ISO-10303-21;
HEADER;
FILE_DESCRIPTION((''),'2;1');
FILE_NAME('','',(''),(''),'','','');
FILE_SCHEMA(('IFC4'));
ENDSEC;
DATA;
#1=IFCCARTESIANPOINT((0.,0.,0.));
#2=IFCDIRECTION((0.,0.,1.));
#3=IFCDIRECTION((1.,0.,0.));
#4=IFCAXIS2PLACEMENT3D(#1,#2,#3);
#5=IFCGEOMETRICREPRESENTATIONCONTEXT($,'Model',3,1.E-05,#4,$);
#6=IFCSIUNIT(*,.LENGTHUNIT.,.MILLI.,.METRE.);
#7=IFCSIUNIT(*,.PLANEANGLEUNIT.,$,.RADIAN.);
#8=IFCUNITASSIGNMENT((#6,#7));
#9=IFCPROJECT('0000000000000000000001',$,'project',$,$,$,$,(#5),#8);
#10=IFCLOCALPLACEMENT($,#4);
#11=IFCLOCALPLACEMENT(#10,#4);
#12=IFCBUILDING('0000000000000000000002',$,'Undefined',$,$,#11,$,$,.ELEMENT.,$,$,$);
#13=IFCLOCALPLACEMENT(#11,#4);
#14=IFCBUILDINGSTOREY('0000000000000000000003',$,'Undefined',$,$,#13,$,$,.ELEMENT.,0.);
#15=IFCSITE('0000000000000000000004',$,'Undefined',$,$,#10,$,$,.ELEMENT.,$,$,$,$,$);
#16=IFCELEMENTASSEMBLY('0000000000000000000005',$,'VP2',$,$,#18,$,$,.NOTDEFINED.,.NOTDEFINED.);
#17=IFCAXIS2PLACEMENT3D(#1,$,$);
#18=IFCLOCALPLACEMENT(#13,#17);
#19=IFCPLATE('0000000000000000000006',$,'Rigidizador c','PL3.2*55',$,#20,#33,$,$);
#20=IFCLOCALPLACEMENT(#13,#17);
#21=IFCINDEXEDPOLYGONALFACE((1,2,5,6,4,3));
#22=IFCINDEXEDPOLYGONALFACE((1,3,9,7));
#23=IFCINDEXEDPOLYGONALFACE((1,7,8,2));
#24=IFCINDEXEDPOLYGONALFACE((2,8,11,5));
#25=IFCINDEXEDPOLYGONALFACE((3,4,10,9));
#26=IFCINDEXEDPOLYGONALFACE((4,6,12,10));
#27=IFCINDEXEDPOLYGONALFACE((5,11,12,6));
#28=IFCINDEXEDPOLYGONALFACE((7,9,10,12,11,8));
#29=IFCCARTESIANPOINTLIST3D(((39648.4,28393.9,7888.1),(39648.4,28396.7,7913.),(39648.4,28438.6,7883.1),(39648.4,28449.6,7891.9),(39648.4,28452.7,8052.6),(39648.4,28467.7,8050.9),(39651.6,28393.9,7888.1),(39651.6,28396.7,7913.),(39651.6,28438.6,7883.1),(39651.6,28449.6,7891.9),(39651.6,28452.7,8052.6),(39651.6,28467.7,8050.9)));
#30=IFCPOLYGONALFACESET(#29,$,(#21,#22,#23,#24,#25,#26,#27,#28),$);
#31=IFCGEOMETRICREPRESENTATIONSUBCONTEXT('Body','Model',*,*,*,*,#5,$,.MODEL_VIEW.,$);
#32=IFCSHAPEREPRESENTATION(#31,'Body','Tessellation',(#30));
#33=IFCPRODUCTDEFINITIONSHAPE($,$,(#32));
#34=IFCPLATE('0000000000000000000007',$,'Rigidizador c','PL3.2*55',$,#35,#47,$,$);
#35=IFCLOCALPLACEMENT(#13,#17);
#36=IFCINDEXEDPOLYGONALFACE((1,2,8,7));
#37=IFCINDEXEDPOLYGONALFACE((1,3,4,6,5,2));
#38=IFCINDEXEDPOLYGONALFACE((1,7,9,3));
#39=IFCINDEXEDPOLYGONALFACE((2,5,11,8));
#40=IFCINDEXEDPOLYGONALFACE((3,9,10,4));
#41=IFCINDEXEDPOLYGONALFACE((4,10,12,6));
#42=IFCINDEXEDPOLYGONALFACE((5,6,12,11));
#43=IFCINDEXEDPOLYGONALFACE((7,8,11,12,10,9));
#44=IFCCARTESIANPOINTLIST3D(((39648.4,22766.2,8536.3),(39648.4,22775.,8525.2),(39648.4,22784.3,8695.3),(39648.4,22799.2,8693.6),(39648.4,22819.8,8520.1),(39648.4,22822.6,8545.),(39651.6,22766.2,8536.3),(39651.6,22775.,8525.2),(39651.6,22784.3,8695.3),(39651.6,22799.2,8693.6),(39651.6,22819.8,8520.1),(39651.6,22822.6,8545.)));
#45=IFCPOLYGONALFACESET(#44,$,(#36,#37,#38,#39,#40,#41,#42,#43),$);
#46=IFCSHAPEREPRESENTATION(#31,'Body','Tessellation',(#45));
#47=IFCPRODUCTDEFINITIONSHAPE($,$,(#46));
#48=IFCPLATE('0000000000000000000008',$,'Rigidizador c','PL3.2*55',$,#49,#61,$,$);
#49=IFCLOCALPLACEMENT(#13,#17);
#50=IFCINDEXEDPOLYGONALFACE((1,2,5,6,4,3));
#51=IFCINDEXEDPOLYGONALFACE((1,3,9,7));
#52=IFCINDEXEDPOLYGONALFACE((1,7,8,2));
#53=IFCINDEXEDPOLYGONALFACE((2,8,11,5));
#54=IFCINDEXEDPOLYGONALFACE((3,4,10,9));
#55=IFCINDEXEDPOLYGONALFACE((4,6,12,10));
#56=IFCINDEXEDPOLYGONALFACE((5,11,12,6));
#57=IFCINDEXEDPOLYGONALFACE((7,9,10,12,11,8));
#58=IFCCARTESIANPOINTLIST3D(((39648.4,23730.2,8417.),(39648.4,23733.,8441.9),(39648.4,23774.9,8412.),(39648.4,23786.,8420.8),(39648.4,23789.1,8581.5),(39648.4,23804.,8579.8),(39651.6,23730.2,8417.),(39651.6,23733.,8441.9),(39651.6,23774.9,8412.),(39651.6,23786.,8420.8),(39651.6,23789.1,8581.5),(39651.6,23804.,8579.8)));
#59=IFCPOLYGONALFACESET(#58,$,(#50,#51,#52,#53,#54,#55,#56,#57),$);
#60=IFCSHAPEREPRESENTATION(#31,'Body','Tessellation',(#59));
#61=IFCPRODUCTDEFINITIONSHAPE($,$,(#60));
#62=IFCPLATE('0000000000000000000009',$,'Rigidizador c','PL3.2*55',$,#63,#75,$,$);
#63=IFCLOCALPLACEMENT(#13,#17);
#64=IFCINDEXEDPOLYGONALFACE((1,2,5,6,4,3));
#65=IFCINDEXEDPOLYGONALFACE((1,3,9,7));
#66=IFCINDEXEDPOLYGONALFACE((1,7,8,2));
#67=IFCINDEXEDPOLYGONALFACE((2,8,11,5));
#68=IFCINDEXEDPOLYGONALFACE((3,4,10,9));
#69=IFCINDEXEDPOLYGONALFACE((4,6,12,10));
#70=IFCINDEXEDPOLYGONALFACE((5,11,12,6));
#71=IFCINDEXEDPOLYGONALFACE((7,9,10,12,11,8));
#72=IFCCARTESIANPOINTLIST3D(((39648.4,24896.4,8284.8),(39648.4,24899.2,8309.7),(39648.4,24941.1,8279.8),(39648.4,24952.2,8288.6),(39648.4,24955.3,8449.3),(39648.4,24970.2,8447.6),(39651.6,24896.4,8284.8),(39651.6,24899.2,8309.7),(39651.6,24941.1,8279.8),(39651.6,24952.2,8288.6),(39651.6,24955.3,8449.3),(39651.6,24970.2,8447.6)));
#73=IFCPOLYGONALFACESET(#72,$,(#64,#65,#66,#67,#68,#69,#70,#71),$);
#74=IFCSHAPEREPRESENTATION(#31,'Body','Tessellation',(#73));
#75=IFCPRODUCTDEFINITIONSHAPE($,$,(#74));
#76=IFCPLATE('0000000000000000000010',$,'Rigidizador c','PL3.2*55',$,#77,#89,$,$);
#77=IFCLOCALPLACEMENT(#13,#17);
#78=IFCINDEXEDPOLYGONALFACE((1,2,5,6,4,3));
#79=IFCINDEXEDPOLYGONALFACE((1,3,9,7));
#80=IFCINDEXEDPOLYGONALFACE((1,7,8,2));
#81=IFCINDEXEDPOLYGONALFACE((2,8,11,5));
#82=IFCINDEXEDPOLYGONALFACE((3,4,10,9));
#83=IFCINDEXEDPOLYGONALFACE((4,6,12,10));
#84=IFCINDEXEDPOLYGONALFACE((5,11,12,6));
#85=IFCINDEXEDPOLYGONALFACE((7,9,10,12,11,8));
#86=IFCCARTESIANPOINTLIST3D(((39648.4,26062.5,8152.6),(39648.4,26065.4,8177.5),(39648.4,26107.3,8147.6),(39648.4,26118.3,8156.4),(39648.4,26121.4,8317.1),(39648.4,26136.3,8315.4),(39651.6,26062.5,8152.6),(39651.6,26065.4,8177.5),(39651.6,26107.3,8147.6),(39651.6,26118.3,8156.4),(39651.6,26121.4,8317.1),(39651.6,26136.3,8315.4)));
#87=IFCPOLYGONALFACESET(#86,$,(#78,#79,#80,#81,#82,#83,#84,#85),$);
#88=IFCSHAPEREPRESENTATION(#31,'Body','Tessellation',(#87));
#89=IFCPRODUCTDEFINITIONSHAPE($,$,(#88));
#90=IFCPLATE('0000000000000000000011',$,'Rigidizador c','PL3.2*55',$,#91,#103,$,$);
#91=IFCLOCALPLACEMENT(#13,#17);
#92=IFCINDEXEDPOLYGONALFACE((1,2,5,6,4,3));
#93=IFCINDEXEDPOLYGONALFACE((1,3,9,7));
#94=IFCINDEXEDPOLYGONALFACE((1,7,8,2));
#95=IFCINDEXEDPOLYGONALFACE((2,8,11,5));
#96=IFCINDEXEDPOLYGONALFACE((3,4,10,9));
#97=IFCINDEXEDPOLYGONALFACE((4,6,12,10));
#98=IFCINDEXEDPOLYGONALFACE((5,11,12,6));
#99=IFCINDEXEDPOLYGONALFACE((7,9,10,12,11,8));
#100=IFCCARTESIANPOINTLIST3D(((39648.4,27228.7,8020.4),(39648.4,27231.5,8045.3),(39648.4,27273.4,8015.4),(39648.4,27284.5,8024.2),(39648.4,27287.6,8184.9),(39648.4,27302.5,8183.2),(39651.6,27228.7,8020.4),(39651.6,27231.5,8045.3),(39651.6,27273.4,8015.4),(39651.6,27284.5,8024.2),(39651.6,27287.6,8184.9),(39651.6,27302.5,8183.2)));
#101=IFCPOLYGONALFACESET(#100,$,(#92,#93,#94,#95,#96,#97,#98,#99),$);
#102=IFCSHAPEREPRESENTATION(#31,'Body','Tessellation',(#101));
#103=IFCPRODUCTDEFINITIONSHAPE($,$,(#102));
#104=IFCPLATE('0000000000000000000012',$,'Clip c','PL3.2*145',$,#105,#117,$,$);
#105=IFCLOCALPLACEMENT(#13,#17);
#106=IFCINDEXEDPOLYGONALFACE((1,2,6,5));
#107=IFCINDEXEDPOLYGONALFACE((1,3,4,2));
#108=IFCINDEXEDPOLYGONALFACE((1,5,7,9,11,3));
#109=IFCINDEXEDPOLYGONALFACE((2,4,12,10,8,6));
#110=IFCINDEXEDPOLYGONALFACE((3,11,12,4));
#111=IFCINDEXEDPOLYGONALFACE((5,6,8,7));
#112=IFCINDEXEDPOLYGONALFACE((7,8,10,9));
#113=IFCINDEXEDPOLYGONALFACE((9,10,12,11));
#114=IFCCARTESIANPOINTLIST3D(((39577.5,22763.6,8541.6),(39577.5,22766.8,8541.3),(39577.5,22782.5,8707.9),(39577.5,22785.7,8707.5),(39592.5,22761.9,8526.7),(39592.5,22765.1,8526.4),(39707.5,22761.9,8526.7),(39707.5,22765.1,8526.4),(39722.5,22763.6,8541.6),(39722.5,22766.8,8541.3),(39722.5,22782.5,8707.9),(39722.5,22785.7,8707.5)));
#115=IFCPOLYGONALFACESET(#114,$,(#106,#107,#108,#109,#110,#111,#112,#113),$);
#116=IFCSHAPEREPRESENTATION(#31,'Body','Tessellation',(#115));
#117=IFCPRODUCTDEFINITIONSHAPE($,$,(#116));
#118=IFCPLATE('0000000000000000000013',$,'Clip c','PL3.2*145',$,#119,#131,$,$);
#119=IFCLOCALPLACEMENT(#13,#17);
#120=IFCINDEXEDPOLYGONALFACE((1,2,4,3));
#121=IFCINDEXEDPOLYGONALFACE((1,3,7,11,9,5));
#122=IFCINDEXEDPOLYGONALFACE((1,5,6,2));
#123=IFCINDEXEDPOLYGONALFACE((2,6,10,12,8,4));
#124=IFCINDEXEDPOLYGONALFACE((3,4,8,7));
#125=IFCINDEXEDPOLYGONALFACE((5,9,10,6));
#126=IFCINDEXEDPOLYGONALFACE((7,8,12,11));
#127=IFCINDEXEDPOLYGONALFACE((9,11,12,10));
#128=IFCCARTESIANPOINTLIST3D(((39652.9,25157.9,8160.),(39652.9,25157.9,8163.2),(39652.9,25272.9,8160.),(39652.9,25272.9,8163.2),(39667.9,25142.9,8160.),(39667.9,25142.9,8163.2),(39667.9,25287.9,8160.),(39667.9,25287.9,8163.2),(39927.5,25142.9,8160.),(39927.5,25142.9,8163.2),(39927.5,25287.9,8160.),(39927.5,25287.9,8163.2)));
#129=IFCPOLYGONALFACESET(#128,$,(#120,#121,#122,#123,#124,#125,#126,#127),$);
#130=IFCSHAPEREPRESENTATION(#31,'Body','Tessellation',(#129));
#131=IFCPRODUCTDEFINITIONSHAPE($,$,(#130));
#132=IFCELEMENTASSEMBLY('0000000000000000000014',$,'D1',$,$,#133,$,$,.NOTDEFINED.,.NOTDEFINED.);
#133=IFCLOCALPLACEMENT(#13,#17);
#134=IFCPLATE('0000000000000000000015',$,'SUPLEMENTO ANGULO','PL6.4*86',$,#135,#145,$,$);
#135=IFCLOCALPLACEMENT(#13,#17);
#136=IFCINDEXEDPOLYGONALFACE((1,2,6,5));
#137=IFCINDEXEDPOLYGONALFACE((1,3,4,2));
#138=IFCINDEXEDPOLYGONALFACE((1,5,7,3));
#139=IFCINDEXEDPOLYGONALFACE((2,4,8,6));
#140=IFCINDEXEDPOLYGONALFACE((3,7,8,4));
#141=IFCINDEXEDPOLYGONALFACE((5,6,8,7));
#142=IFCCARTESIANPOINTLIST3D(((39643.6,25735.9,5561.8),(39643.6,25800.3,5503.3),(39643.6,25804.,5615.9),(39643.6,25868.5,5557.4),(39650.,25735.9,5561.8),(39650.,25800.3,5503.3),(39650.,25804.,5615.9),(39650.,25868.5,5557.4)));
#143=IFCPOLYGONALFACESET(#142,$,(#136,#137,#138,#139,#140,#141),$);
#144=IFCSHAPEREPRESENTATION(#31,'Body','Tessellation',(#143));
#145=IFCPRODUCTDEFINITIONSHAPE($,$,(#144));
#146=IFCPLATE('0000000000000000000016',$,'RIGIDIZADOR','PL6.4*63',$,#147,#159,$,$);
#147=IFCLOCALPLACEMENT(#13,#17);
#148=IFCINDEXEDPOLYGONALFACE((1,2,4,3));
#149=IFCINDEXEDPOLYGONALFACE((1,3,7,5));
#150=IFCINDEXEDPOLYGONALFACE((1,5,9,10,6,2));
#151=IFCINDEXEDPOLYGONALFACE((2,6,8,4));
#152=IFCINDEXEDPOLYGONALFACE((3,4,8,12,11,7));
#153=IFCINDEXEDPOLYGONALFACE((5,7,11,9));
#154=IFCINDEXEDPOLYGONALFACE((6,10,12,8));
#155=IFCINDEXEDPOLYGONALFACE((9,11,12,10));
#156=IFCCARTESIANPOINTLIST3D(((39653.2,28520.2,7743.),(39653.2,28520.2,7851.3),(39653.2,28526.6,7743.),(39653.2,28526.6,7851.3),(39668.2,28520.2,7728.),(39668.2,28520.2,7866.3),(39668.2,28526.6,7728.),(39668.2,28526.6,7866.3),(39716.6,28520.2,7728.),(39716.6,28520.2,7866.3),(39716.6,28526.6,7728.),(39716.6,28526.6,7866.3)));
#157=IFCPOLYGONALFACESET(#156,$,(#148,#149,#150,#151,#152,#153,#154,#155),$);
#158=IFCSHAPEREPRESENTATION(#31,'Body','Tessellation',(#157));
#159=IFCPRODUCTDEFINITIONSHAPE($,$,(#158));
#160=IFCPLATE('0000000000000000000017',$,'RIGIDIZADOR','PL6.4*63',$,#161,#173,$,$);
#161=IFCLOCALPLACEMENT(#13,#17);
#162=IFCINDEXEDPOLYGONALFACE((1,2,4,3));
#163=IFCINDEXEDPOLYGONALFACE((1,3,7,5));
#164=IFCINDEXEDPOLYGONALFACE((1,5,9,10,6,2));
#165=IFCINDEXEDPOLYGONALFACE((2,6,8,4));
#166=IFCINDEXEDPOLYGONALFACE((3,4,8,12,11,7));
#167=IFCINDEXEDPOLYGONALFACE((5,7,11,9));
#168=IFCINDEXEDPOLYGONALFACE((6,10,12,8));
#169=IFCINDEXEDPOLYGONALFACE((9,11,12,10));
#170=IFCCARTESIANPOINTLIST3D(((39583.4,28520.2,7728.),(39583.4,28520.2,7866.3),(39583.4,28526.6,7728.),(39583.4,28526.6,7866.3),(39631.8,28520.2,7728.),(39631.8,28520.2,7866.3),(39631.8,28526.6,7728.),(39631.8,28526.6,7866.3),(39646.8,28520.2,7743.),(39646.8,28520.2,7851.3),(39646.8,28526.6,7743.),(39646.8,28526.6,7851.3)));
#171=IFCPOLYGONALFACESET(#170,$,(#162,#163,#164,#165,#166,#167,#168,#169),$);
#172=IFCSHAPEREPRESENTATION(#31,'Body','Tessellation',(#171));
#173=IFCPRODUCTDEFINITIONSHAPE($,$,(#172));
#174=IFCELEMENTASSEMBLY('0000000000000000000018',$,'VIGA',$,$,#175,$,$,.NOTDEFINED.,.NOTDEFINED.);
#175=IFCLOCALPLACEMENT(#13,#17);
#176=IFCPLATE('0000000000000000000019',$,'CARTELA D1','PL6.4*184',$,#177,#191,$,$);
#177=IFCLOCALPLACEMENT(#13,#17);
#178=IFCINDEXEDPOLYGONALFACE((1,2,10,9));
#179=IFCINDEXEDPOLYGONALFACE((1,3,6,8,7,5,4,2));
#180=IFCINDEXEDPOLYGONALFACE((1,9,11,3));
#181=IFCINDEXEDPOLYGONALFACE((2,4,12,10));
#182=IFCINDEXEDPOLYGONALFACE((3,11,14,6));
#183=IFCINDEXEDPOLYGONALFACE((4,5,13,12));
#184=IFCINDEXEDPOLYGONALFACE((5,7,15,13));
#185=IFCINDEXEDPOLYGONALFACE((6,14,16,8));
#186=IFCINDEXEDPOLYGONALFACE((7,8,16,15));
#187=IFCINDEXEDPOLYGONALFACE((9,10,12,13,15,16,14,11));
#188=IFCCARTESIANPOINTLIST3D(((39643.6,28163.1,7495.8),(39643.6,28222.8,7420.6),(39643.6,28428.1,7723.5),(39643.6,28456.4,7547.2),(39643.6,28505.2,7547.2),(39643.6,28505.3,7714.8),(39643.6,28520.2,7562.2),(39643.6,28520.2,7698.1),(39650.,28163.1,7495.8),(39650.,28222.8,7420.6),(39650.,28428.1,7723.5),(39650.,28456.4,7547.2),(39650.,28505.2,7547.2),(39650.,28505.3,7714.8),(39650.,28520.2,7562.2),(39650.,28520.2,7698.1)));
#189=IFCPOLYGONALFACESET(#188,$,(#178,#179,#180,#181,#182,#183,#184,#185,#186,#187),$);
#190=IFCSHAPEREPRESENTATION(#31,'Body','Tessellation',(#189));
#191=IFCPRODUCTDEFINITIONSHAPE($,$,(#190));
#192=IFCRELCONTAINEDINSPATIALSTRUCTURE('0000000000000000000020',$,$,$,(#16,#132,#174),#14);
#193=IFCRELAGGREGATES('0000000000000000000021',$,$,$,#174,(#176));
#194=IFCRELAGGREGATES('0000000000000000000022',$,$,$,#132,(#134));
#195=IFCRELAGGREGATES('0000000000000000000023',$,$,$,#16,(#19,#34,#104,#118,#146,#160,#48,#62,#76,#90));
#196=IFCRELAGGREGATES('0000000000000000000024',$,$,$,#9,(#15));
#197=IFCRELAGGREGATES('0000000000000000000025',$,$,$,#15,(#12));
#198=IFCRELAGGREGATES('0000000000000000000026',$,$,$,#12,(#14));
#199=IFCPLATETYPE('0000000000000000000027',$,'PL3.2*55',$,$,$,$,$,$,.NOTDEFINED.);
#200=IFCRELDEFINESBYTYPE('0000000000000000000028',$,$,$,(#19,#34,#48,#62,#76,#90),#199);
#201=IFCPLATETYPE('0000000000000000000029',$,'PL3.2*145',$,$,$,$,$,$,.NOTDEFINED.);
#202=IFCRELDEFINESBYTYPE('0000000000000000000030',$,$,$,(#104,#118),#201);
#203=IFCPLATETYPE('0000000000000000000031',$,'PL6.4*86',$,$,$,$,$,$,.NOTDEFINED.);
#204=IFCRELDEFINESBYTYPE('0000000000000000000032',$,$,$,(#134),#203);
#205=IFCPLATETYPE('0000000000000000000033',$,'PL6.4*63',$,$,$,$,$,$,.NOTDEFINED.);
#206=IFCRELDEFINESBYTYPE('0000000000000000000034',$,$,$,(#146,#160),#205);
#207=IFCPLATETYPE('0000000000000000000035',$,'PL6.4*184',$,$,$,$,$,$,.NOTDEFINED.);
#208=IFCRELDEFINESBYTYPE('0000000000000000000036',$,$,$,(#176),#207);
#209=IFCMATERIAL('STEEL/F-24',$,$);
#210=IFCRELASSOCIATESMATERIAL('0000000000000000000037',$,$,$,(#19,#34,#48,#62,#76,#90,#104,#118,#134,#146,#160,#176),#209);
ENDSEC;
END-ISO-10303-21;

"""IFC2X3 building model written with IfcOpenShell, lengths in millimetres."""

from ifc_helpers import new_model, si_unit, frame, origin_with_axes, place, context, subcontext, project, spatial, polyline, outline, extrude, material, type_object, element, aggregate, save


model = new_model("IFC2X3")

# Units and contexts
model_context = context("Model", 3, precision=1e-05, world=origin_with_axes())
body_context = subcontext(model_context, "Body", "Model", "MODEL_VIEW")
ifc_project = project(units=[si_unit("LENGTHUNIT", "METRE", prefix="MILLI"), si_unit("PLANEANGLEUNIT", "RADIAN")], contexts=[model_context])

# Site, building, storey
site_placement = place(None, origin_with_axes())
site = spatial("IfcSite", under=ifc_project, at=site_placement, Name="Undefined", CompositionType="ELEMENT")
building_placement = place(site_placement, origin_with_axes())
building = spatial("IfcBuilding", under=site, at=building_placement, Name="Undefined", CompositionType="ELEMENT")
storey_placement = place(building_placement, origin_with_axes())
storey = spatial("IfcBuildingStorey", under=building, at=storey_placement, Name="Undefined", CompositionType="ELEMENT", Elevation=0.0)

# Element assembly, plates
assembly_1_placement = place(storey_placement, origin_with_axes())
assembly_1 = element("IfcElementAssembly", 1, at=assembly_1_placement, inside=storey, Name="VP2", AssemblyPlace="NOTDEFINED", PredefinedType="NOTDEFINED")
ifc_material_1 = material(Name="STEEL/F-24")
plate_type_1 = type_object("IfcPlateType", Name="PL3.2*55", PredefinedType="NOTDEFINED")
plate_1_placement = place(assembly_1_placement, frame((39650.0, 28467.7, 8050.9), z_axis=(1.0, 0.0, 0.0), x_axis=(0.0, -0.993635, 0.112644)))
plate_1 = element("IfcPlate", 2, at=plate_1_placement, type_object=plate_type_1, material=ifc_material_1, Name="Rigidizador c", Description="PL3.2*55", context=body_context, shape_type="SweptSolid", body=[
    extrude(outline(polyline([(0.0, 0.0), (15.0, 0.0), (55.0, 145.0), (55.0, 170.1), (10.0, 170.0), (0.0, 160.0), (0.0, 0.0)])), frame((0.0, 0.0, -1.6), z_axis=(0.0, 0.0, 1.0), x_axis=(1.0, 0.0, 0.0)), (0.0, 0.0, 1.0), 3.2),
])
plate_2_placement = place(assembly_1_placement, frame((39650.0, 22784.3, 8695.3), z_axis=(-1.0, 0.0, 0.0), x_axis=(0.0, 0.993635, -0.112644)))
plate_2 = element("IfcPlate", 3, at=plate_2_placement, type_object=plate_type_1, material=ifc_material_1, Name="Rigidizador c", Description="PL3.2*55", context=body_context, shape_type="SweptSolid", body=[
    extrude(outline(polyline([(0.0, 0.0), (15.0, 0.0), (55.0, 145.0), (55.0, 170.1), (10.0, 170.0), (0.0, 160.0), (0.0, 0.0)])), frame((0.0, 0.0, -1.6), z_axis=(0.0, 0.0, 1.0), x_axis=(1.0, 0.0, 0.0)), (0.0, 0.0, 1.0), 3.2),
])
plate_3_placement = place(assembly_1_placement, frame((39650.0, 23804.0, 8579.8), z_axis=(1.0, 0.0, 0.0), x_axis=(0.0, -0.993635, 0.112644)))
plate_3 = element("IfcPlate", 4, at=plate_3_placement, type_object=plate_type_1, material=ifc_material_1, Name="Rigidizador c", Description="PL3.2*55", context=body_context, shape_type="SweptSolid", body=[
    extrude(outline(polyline([(0.0, 0.0), (15.0, 0.0), (55.0, 145.0), (55.0, 170.1), (10.0, 170.0), (0.0, 160.0), (0.0, 0.0)])), frame((0.0, 0.0, -1.6), z_axis=(0.0, 0.0, 1.0), x_axis=(1.0, 0.0, 0.0)), (0.0, 0.0, 1.0), 3.2),
])
plate_4_placement = place(assembly_1_placement, frame((39650.0, 24970.2, 8447.6), z_axis=(1.0, 0.0, 0.0), x_axis=(0.0, -0.993635, 0.112644)))
plate_4 = element("IfcPlate", 5, at=plate_4_placement, type_object=plate_type_1, material=ifc_material_1, Name="Rigidizador c", Description="PL3.2*55", context=body_context, shape_type="SweptSolid", body=[
    extrude(outline(polyline([(0.0, 0.0), (15.0, 0.0), (55.0, 145.0), (55.0, 170.1), (10.0, 170.0), (0.0, 160.0), (0.0, 0.0)])), frame((0.0, 0.0, -1.6), z_axis=(0.0, 0.0, 1.0), x_axis=(1.0, 0.0, 0.0)), (0.0, 0.0, 1.0), 3.2),
])
plate_5_placement = place(assembly_1_placement, frame((39650.0, 26136.3, 8315.4), z_axis=(1.0, 0.0, 0.0), x_axis=(0.0, -0.993635, 0.112644)))
plate_5 = element("IfcPlate", 6, at=plate_5_placement, type_object=plate_type_1, material=ifc_material_1, Name="Rigidizador c", Description="PL3.2*55", context=body_context, shape_type="SweptSolid", body=[
    extrude(outline(polyline([(0.0, 0.0), (15.0, 0.0), (55.0, 145.0), (55.0, 170.1), (10.0, 170.0), (0.0, 160.0), (0.0, 0.0)])), frame((0.0, 0.0, -1.6), z_axis=(0.0, 0.0, 1.0), x_axis=(1.0, 0.0, 0.0)), (0.0, 0.0, 1.0), 3.2),
])
plate_6_placement = place(assembly_1_placement, frame((39650.0, 27302.5, 8183.2), z_axis=(1.0, 0.0, 0.0), x_axis=(0.0, -0.993635, 0.112644)))
plate_6 = element("IfcPlate", 7, at=plate_6_placement, type_object=plate_type_1, material=ifc_material_1, Name="Rigidizador c", Description="PL3.2*55", context=body_context, shape_type="SweptSolid", body=[
    extrude(outline(polyline([(0.0, 0.0), (15.0, 0.0), (55.0, 145.0), (55.0, 170.1), (10.0, 170.0), (0.0, 160.0), (0.0, 0.0)])), frame((0.0, 0.0, -1.6), z_axis=(0.0, 0.0, 1.0), x_axis=(1.0, 0.0, 0.0)), (0.0, 0.0, 1.0), 3.2),
])
plate_type_2 = type_object("IfcPlateType", Name="PL3.2*145", PredefinedType="NOTDEFINED")
plate_7_placement = place(assembly_1_placement, frame((39722.5, 22763.5, 8526.5), z_axis=(0.0, -0.993626, 0.112729), x_axis=(0.0, 0.112729, 0.993626)))
plate_7 = element("IfcPlate", 8, at=plate_7_placement, type_object=plate_type_2, material=ifc_material_1, Name="Clip c", Description="PL3.2*145", context=body_context, shape_type="SweptSolid", body=[
    extrude(outline(polyline([(0.0, 15.0), (15.0, 0.0), (182.3, 0.0), (182.3, 145.0), (15.0, 145.0), (0.0, 130.0), (0.0, 15.0)])), frame((0.0, 0.0, -1.6), z_axis=(0.0, 0.0, 1.0), x_axis=(1.0, 0.0, 0.0)), (0.0, 0.0, 1.0), 3.2),
])
plate_8_placement = place(assembly_1_placement, frame((39652.9, 25142.9, 8161.6), z_axis=(-0.000054, 0.0, 1.0), x_axis=(1.0, 0.0, 0.000055)))
plate_8 = element("IfcPlate", 9, at=plate_8_placement, type_object=plate_type_2, material=ifc_material_1, Name="Clip c", Description="PL3.2*145", context=body_context, shape_type="SweptSolid", body=[
    extrude(outline(polyline([(0.0, 15.0), (15.0, 0.0), (274.6, 0.0), (274.6, 145.0), (15.0, 145.0), (0.0, 130.0), (0.0, 15.0)])), frame((0.0, 0.0, -1.6), z_axis=(0.0, 0.0, 1.0), x_axis=(1.0, 0.0, 0.0)), (0.0, 0.0, 1.0), 3.2),
])

# Element assembly, plate
assembly_2_placement = place(storey_placement, origin_with_axes())
assembly_2 = element("IfcElementAssembly", 10, at=assembly_2_placement, inside=storey, Name="D1", AssemblyPlace="NOTDEFINED", PredefinedType="NOTDEFINED")
plate_type_3 = type_object("IfcPlateType", Name="PL6.4*86", PredefinedType="NOTDEFINED")
plate_9_placement = place(assembly_2_placement, frame((39646.8, 25868.5, 5557.4), z_axis=(1.0, 0.0, 0.0), x_axis=(0.0, -0.740512, 0.672043)))
plate_9 = element("IfcPlate", 11, at=plate_9_placement, type_object=plate_type_3, material=ifc_material_1, Name="SUPLEMENTO ANGULO", Description="PL6.4*86", context=body_context, shape_type="SweptSolid", body=[
    extrude(outline(polyline([(0.0, 0.0), (87.0, 0.0), (101.1, 85.9), (14.1, 85.9), (0.0, 0.0)])), frame((0.0, 0.0, -3.2), z_axis=(0.0, 0.0, 1.0), x_axis=(1.0, 0.0, 0.0)), (0.0, 0.0, 1.0), 6.4),
])

# Plates
plate_type_4 = type_object("IfcPlateType", Name="PL6.4*63", PredefinedType="NOTDEFINED")
plate_10_placement = place(assembly_1_placement, frame((39716.6, 28523.4, 7728.0), z_axis=(0.0, 1.0, 0.0), x_axis=(-1.0, 0.0, 0.0)))
plate_10 = element("IfcPlate", 12, at=plate_10_placement, type_object=plate_type_4, material=ifc_material_1, Name="RIGIDIZADOR", Description="PL6.4*63", context=body_context, shape_type="SweptSolid", body=[
    extrude(outline(polyline([(0.0, 0.0), (48.4, 0.0), (63.4, 15.0), (63.4, 123.4), (48.4, 138.4), (0.0, 138.4), (0.0, 0.0)])), frame((0.0, 0.0, -3.2), z_axis=(0.0, 0.0, 1.0), x_axis=(1.0, 0.0, 0.0)), (0.0, 0.0, 1.0), 6.4),
])
plate_11_placement = place(assembly_1_placement, frame((39646.8, 28523.4, 7728.0), z_axis=(0.0, 1.0, 0.0), x_axis=(-1.0, 0.0, 0.0)))
plate_11 = element("IfcPlate", 13, at=plate_11_placement, type_object=plate_type_4, material=ifc_material_1, Name="RIGIDIZADOR", Description="PL6.4*63", context=body_context, shape_type="SweptSolid", body=[
    extrude(outline(polyline([(0.0, 15.0), (15.0, 0.0), (63.4, 0.0), (63.4, 138.4), (15.0, 138.4), (0.0, 123.4), (0.0, 15.0)])), frame((0.0, 0.0, -3.2), z_axis=(0.0, 0.0, 1.0), x_axis=(1.0, 0.0, 0.0)), (0.0, 0.0, 1.0), 6.4),
])

# Element assembly, plate
assembly_3_placement = place(storey_placement, origin_with_axes())
assembly_3 = element("IfcElementAssembly", 14, at=assembly_3_placement, inside=storey, Name="VIGA", AssemblyPlace="NOTDEFINED", PredefinedType="NOTDEFINED")
plate_type_5 = type_object("IfcPlateType", Name="PL6.4*184", PredefinedType="NOTDEFINED")
plate_12_placement = place(assembly_3_placement, frame((39646.8, 28520.2, 7547.2), z_axis=(1.0, 0.0, 0.0), x_axis=(0.0, 0.0, 1.0)))
plate_12 = element("IfcPlate", 15, at=plate_12_placement, type_object=plate_type_5, material=ifc_material_1, Name="CARTELA D1", Description="PL6.4*184", context=body_context, shape_type="SweptSolid", body=[
    extrude(outline(polyline([(0.0, 15.0), (15.0, 0.0), (150.8, 0.0), (167.5, 14.9), (176.3, 92.1), (-51.4, 357.1), (-126.6, 297.4), (0.0, 63.8), (0.0, 15.0)])), frame((0.0, 0.0, -3.2), z_axis=(0.0, 0.0, 1.0), x_axis=(1.0, 0.0, 0.0)), (0.0, 0.0, 1.0), 6.4),
])
aggregate(assembly_3, [plate_12])

aggregate(assembly_2, [plate_9])

aggregate(assembly_1, [plate_1, plate_2, plate_7, plate_8, plate_10, plate_11, plate_3, plate_4, plate_5, plate_6])

save(model, "model.ifc")
